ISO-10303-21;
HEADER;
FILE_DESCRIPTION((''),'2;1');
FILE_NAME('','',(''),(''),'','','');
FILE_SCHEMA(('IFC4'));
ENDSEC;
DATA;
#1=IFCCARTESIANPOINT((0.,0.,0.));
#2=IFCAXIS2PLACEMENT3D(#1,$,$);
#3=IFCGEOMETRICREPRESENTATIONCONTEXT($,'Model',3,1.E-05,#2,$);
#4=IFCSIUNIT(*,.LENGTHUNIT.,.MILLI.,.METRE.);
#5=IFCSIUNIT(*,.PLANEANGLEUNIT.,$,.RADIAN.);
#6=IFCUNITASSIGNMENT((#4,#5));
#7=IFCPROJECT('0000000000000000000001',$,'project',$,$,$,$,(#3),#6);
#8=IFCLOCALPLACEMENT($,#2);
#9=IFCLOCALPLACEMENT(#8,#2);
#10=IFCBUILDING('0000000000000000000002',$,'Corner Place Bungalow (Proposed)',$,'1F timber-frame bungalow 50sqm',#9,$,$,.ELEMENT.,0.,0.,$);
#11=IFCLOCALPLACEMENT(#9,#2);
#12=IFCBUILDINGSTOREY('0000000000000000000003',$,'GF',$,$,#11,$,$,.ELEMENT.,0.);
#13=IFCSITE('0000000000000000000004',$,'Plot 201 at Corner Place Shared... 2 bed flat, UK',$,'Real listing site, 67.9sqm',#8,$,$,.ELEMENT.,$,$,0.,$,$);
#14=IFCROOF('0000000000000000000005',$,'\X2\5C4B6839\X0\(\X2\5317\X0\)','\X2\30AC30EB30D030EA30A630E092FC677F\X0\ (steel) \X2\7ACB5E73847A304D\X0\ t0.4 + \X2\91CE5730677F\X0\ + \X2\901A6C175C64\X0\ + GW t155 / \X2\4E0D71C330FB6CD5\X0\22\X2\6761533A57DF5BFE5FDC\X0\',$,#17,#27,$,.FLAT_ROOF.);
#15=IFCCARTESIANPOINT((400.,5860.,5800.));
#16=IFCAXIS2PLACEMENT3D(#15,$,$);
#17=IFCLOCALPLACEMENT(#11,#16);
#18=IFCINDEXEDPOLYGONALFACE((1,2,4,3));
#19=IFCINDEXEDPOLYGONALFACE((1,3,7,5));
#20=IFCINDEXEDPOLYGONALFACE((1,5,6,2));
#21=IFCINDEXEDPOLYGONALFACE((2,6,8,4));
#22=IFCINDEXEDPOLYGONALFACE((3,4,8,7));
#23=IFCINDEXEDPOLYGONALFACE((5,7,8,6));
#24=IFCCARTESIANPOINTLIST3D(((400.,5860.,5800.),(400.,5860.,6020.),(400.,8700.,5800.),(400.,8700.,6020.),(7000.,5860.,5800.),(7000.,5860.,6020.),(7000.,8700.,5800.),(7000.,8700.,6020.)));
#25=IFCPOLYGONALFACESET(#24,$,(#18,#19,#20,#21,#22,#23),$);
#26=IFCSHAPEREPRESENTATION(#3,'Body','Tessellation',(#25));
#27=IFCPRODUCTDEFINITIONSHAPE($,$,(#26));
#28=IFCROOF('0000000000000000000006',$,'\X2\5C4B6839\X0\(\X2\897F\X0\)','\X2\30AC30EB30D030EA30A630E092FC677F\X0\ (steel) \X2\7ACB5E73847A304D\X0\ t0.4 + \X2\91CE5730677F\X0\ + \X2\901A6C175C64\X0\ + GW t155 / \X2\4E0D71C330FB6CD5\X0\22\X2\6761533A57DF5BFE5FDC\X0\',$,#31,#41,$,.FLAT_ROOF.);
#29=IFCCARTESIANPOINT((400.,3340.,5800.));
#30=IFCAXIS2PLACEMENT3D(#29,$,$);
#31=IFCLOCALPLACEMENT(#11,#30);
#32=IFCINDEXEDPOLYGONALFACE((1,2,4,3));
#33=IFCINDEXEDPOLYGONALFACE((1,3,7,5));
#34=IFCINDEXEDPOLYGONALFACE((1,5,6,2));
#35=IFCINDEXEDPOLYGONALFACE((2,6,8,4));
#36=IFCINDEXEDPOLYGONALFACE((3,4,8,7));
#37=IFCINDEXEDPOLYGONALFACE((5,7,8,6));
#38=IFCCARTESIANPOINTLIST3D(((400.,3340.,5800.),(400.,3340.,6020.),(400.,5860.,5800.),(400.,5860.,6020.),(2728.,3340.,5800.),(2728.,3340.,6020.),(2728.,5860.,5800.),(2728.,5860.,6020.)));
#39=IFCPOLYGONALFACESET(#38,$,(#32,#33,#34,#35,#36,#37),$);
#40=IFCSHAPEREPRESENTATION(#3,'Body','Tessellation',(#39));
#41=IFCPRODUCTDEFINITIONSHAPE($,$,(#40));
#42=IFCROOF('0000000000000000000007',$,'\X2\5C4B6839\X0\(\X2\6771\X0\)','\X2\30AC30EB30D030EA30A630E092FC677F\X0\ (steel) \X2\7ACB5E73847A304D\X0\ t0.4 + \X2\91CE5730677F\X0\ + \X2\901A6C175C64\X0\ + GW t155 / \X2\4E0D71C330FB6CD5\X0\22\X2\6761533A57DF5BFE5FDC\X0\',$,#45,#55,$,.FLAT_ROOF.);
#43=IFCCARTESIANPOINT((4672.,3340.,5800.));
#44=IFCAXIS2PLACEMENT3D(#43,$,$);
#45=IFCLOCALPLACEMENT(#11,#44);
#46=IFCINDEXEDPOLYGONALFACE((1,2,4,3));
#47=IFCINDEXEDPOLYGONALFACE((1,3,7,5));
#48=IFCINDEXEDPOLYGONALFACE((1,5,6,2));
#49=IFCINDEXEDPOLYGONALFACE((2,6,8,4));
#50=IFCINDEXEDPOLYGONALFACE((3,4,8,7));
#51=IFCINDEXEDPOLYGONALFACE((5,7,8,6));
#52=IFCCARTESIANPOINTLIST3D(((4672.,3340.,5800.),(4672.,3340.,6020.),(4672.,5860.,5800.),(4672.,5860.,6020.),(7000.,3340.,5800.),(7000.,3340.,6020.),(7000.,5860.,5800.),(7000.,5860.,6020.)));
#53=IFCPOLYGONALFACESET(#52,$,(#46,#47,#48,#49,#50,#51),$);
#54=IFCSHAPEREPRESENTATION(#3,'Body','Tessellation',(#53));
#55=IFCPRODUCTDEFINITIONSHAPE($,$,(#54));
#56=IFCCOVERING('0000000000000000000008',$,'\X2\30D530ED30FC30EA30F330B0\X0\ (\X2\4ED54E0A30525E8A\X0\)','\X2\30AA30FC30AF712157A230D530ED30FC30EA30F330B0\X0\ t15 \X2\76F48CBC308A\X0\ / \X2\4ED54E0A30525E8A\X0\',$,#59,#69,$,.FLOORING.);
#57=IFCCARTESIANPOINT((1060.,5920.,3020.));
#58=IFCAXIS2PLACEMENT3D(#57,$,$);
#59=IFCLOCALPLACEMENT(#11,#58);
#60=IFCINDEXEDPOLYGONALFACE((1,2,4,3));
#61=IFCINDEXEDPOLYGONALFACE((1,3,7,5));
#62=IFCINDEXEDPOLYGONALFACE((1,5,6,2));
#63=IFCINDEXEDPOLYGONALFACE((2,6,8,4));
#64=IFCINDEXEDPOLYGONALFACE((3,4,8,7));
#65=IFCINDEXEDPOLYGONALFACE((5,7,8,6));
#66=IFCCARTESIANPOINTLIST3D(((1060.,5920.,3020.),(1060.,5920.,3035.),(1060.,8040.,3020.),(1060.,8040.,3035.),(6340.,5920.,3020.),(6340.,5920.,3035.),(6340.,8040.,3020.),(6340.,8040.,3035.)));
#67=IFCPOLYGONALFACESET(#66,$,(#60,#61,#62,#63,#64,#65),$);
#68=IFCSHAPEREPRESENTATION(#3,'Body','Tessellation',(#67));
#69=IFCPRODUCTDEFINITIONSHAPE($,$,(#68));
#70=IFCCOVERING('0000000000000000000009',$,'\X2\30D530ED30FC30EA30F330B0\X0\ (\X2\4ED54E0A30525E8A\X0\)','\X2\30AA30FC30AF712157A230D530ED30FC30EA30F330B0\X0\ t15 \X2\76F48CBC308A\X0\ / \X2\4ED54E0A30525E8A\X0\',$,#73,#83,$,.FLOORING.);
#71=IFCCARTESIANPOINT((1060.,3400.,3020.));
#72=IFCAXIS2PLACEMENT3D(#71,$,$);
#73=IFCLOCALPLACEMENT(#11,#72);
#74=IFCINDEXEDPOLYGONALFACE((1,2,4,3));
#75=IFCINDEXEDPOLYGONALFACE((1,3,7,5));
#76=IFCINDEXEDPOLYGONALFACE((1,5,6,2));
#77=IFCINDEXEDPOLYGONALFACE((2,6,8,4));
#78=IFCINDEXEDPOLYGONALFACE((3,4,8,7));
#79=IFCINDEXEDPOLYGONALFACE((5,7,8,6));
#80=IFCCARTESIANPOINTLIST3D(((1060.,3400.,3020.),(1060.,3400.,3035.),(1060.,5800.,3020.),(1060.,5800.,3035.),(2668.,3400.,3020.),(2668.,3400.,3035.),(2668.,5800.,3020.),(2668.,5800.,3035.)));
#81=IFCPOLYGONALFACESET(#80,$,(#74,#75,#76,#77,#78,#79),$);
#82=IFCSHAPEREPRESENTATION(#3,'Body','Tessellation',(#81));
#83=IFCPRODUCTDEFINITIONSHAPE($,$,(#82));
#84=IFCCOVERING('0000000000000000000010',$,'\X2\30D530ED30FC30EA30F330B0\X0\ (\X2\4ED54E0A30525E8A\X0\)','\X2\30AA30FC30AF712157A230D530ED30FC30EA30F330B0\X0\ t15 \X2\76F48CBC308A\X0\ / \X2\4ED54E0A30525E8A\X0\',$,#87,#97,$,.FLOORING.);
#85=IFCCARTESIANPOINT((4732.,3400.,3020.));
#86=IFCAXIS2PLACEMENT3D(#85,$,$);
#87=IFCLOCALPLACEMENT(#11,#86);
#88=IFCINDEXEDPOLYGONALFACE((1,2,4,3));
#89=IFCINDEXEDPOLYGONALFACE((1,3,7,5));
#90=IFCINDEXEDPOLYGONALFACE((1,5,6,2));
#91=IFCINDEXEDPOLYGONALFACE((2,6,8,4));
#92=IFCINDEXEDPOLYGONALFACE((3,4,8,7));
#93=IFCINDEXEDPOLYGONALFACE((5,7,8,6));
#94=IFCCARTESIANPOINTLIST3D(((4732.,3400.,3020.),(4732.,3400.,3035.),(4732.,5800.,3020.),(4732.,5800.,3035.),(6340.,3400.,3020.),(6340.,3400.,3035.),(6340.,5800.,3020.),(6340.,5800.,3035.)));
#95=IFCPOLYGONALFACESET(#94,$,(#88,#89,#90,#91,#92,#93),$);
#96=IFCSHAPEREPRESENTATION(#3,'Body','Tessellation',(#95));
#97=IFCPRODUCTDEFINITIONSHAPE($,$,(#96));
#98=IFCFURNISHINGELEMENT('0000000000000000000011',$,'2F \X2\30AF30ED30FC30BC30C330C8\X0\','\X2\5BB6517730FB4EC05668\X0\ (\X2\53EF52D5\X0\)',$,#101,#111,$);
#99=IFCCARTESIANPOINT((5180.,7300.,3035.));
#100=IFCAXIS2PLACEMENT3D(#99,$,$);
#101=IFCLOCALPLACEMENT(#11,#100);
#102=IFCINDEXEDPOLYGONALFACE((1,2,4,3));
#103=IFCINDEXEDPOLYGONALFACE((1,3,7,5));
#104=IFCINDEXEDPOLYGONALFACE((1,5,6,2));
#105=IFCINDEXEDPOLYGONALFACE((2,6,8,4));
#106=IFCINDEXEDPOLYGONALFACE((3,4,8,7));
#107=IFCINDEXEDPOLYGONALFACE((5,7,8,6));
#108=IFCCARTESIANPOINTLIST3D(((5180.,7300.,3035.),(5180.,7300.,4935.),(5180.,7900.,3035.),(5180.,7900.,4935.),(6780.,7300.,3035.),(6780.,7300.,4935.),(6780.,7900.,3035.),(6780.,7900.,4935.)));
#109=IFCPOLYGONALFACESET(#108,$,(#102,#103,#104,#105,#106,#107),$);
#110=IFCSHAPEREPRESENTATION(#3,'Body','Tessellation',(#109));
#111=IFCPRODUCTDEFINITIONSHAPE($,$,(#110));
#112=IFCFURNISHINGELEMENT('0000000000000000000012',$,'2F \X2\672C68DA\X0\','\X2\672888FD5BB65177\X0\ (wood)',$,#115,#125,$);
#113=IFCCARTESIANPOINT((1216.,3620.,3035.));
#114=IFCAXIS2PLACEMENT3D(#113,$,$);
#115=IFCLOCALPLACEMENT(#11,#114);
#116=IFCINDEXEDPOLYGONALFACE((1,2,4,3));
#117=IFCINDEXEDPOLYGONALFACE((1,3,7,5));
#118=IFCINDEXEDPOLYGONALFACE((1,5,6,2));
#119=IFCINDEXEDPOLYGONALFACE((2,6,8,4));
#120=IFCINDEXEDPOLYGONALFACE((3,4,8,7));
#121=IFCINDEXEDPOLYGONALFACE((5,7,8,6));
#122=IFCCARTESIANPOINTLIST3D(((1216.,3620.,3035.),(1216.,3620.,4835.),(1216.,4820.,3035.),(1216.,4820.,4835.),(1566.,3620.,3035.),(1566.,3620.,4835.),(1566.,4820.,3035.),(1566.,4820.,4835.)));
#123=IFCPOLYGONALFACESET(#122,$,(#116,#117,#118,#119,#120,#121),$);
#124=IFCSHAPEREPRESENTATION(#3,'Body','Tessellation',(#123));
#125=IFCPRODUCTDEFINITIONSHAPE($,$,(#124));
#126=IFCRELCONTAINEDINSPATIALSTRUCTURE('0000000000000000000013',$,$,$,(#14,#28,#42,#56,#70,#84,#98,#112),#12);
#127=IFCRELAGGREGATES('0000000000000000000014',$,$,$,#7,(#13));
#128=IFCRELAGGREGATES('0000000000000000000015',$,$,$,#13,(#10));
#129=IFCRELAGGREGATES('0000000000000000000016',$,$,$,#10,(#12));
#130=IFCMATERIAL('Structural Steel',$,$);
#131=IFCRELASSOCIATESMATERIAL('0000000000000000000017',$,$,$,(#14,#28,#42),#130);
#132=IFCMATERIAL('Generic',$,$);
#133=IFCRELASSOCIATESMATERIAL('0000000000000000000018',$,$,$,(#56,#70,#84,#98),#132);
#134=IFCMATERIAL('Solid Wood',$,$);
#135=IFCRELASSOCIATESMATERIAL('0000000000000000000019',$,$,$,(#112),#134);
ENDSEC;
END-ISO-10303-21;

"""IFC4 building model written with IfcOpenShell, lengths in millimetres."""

from ifc_helpers import new_model, si_unit, frame, frame_2d, origin, place, context, project, spatial, rectangle, extrude, material, element, save


model = new_model("IFC4")

# Units and contexts
model_context = context("Model", 3, precision=1e-05, world=origin())
ifc_project = project(units=[si_unit("LENGTHUNIT", "METRE", prefix="MILLI"), si_unit("PLANEANGLEUNIT", "RADIAN")], contexts=[model_context])

# Site, building, storey
site_placement = place(None, origin())
site = spatial("IfcSite", under=ifc_project, at=site_placement, Name="Plot 201 at Corner Place Shared... 2 bed flat, UK", ObjectType="Real listing site, 67.9sqm", CompositionType="ELEMENT", RefElevation=0.0)
building_placement = place(site_placement, origin())
building = spatial("IfcBuilding", under=site, at=building_placement, Name="Corner Place Bungalow (Proposed)", ObjectType="1F timber-frame bungalow 50sqm", CompositionType="ELEMENT", ElevationOfRefHeight=0.0, ElevationOfTerrain=0.0)
storey_placement = place(building_placement, origin())
storey = spatial("IfcBuildingStorey", under=building, at=storey_placement, Name="GF", CompositionType="ELEMENT", Elevation=0.0)

# Shared definitions
ifc_material_1 = material(Name="Solid Wood")

# Shared definitions
ifc_material_2 = material(Name="Generic")

# Roofs
ifc_material_3 = material(Name="Structural Steel")
for number, where, name in (
    (1, (400.0, 5860.0, 5800.0), "屋根(北)"),
):
    element("IfcRoof", number, at=place(storey_placement, frame(where)), inside=storey, material=ifc_material_3, Name=name, Description="ガルバリウム鋼板 (steel) 立平葺き t0.4 + 野地板 + 通気層 + GW t155 / 不燃・法22条区域対応", PredefinedType="FLAT_ROOF", context=model_context, shape_type="SweptSolid", body=[
        extrude(rectangle(XDim=6600.0, YDim=2840.0, at=frame_2d((3300.0, 1420.0))), frame((400.0, 5860.0, 5800.0)), (0.0, 0.0, 1.0), 220.0),
    ])
roof_1_placement = place(storey_placement, frame((400.0, 3340.0, 5800.0)))
element("IfcRoof", 2, at=roof_1_placement, inside=storey, material=ifc_material_3, Name="屋根(西)", Description="ガルバリウム鋼板 (steel) 立平葺き t0.4 + 野地板 + 通気層 + GW t155 / 不燃・法22条区域対応", PredefinedType="FLAT_ROOF", context=model_context, shape_type="SweptSolid", body=[
    extrude(rectangle(XDim=2328.0, YDim=2520.0, at=frame_2d((1164.0, 1260.0))), frame((400.0, 3340.0, 5800.0)), (0.0, 0.0, 1.0), 220.0),
])
roof_2_placement = place(storey_placement, frame((4672.0, 3340.0, 5800.0)))
element("IfcRoof", 3, at=roof_2_placement, inside=storey, material=ifc_material_3, Name="屋根(東)", Description="ガルバリウム鋼板 (steel) 立平葺き t0.4 + 野地板 + 通気層 + GW t155 / 不燃・法22条区域対応", PredefinedType="FLAT_ROOF", context=model_context, shape_type="SweptSolid", body=[
    extrude(rectangle(XDim=2328.0, YDim=2520.0, at=frame_2d((1164.0, 1260.0))), frame((4672.0, 3340.0, 5800.0)), (0.0, 0.0, 1.0), 220.0),
])

# Coverings
covering_1_placement = place(storey_placement, frame((1060.0, 5920.0, 3020.0)))
element("IfcCovering", 4, at=covering_1_placement, inside=storey, material=ifc_material_2, Name="フローリング (仕上げ床)", Description="オーク無垢フローリング t15 直貼り / 仕上げ床", PredefinedType="FLOORING", context=model_context, shape_type="SweptSolid", body=[
    extrude(rectangle(XDim=5280.0, YDim=2120.0, at=frame_2d((2640.0, 1060.0))), frame((1060.0, 5920.0, 3020.0)), (0.0, 0.0, 1.0), 15.0),
])
covering_2_placement = place(storey_placement, frame((1060.0, 3400.0, 3020.0)))
element("IfcCovering", 5, at=covering_2_placement, inside=storey, material=ifc_material_2, Name="フローリング (仕上げ床)", Description="オーク無垢フローリング t15 直貼り / 仕上げ床", PredefinedType="FLOORING", context=model_context, shape_type="SweptSolid", body=[
    extrude(rectangle(XDim=1608.0, YDim=2400.0, at=frame_2d((804.0, 1200.0))), frame((1060.0, 3400.0, 3020.0)), (0.0, 0.0, 1.0), 15.0),
])
covering_3_placement = place(storey_placement, frame((4732.0, 3400.0, 3020.0)))
element("IfcCovering", 6, at=covering_3_placement, inside=storey, material=ifc_material_2, Name="フローリング (仕上げ床)", Description="オーク無垢フローリング t15 直貼り / 仕上げ床", PredefinedType="FLOORING", context=model_context, shape_type="SweptSolid", body=[
    extrude(rectangle(XDim=1608.0, YDim=2400.0, at=frame_2d((804.0, 1200.0))), frame((4732.0, 3400.0, 3020.0)), (0.0, 0.0, 1.0), 15.0),
])

# Furnishing elements
furnishing_1_placement = place(storey_placement, frame((5180.0, 7300.0, 3035.0)))
element("IfcFurnishingElement", 7, at=furnishing_1_placement, inside=storey, material=ifc_material_2, Name="2F クローゼット", Description="家具・什器 (可動)", context=model_context, shape_type="SweptSolid", body=[
    extrude(rectangle(XDim=1600.0, YDim=600.0, at=frame_2d((800.0, 300.0))), frame((5180.0, 7300.0, 3035.0)), (0.0, 0.0, 1.0), 1900.0),
])
furnishing_2_placement = place(storey_placement, frame((1216.0, 3620.0, 3035.0)))
element("IfcFurnishingElement", 8, at=furnishing_2_placement, inside=storey, material=ifc_material_1, Name="2F 本棚", Description="木製家具 (wood)", context=model_context, shape_type="SweptSolid", body=[
    extrude(rectangle(XDim=350.0, YDim=1200.0, at=frame_2d((175.0, 600.0))), frame((1216.0, 3620.0, 3035.0)), (0.0, 0.0, 1.0), 1800.0),
])

save(model, "model.ifc")
